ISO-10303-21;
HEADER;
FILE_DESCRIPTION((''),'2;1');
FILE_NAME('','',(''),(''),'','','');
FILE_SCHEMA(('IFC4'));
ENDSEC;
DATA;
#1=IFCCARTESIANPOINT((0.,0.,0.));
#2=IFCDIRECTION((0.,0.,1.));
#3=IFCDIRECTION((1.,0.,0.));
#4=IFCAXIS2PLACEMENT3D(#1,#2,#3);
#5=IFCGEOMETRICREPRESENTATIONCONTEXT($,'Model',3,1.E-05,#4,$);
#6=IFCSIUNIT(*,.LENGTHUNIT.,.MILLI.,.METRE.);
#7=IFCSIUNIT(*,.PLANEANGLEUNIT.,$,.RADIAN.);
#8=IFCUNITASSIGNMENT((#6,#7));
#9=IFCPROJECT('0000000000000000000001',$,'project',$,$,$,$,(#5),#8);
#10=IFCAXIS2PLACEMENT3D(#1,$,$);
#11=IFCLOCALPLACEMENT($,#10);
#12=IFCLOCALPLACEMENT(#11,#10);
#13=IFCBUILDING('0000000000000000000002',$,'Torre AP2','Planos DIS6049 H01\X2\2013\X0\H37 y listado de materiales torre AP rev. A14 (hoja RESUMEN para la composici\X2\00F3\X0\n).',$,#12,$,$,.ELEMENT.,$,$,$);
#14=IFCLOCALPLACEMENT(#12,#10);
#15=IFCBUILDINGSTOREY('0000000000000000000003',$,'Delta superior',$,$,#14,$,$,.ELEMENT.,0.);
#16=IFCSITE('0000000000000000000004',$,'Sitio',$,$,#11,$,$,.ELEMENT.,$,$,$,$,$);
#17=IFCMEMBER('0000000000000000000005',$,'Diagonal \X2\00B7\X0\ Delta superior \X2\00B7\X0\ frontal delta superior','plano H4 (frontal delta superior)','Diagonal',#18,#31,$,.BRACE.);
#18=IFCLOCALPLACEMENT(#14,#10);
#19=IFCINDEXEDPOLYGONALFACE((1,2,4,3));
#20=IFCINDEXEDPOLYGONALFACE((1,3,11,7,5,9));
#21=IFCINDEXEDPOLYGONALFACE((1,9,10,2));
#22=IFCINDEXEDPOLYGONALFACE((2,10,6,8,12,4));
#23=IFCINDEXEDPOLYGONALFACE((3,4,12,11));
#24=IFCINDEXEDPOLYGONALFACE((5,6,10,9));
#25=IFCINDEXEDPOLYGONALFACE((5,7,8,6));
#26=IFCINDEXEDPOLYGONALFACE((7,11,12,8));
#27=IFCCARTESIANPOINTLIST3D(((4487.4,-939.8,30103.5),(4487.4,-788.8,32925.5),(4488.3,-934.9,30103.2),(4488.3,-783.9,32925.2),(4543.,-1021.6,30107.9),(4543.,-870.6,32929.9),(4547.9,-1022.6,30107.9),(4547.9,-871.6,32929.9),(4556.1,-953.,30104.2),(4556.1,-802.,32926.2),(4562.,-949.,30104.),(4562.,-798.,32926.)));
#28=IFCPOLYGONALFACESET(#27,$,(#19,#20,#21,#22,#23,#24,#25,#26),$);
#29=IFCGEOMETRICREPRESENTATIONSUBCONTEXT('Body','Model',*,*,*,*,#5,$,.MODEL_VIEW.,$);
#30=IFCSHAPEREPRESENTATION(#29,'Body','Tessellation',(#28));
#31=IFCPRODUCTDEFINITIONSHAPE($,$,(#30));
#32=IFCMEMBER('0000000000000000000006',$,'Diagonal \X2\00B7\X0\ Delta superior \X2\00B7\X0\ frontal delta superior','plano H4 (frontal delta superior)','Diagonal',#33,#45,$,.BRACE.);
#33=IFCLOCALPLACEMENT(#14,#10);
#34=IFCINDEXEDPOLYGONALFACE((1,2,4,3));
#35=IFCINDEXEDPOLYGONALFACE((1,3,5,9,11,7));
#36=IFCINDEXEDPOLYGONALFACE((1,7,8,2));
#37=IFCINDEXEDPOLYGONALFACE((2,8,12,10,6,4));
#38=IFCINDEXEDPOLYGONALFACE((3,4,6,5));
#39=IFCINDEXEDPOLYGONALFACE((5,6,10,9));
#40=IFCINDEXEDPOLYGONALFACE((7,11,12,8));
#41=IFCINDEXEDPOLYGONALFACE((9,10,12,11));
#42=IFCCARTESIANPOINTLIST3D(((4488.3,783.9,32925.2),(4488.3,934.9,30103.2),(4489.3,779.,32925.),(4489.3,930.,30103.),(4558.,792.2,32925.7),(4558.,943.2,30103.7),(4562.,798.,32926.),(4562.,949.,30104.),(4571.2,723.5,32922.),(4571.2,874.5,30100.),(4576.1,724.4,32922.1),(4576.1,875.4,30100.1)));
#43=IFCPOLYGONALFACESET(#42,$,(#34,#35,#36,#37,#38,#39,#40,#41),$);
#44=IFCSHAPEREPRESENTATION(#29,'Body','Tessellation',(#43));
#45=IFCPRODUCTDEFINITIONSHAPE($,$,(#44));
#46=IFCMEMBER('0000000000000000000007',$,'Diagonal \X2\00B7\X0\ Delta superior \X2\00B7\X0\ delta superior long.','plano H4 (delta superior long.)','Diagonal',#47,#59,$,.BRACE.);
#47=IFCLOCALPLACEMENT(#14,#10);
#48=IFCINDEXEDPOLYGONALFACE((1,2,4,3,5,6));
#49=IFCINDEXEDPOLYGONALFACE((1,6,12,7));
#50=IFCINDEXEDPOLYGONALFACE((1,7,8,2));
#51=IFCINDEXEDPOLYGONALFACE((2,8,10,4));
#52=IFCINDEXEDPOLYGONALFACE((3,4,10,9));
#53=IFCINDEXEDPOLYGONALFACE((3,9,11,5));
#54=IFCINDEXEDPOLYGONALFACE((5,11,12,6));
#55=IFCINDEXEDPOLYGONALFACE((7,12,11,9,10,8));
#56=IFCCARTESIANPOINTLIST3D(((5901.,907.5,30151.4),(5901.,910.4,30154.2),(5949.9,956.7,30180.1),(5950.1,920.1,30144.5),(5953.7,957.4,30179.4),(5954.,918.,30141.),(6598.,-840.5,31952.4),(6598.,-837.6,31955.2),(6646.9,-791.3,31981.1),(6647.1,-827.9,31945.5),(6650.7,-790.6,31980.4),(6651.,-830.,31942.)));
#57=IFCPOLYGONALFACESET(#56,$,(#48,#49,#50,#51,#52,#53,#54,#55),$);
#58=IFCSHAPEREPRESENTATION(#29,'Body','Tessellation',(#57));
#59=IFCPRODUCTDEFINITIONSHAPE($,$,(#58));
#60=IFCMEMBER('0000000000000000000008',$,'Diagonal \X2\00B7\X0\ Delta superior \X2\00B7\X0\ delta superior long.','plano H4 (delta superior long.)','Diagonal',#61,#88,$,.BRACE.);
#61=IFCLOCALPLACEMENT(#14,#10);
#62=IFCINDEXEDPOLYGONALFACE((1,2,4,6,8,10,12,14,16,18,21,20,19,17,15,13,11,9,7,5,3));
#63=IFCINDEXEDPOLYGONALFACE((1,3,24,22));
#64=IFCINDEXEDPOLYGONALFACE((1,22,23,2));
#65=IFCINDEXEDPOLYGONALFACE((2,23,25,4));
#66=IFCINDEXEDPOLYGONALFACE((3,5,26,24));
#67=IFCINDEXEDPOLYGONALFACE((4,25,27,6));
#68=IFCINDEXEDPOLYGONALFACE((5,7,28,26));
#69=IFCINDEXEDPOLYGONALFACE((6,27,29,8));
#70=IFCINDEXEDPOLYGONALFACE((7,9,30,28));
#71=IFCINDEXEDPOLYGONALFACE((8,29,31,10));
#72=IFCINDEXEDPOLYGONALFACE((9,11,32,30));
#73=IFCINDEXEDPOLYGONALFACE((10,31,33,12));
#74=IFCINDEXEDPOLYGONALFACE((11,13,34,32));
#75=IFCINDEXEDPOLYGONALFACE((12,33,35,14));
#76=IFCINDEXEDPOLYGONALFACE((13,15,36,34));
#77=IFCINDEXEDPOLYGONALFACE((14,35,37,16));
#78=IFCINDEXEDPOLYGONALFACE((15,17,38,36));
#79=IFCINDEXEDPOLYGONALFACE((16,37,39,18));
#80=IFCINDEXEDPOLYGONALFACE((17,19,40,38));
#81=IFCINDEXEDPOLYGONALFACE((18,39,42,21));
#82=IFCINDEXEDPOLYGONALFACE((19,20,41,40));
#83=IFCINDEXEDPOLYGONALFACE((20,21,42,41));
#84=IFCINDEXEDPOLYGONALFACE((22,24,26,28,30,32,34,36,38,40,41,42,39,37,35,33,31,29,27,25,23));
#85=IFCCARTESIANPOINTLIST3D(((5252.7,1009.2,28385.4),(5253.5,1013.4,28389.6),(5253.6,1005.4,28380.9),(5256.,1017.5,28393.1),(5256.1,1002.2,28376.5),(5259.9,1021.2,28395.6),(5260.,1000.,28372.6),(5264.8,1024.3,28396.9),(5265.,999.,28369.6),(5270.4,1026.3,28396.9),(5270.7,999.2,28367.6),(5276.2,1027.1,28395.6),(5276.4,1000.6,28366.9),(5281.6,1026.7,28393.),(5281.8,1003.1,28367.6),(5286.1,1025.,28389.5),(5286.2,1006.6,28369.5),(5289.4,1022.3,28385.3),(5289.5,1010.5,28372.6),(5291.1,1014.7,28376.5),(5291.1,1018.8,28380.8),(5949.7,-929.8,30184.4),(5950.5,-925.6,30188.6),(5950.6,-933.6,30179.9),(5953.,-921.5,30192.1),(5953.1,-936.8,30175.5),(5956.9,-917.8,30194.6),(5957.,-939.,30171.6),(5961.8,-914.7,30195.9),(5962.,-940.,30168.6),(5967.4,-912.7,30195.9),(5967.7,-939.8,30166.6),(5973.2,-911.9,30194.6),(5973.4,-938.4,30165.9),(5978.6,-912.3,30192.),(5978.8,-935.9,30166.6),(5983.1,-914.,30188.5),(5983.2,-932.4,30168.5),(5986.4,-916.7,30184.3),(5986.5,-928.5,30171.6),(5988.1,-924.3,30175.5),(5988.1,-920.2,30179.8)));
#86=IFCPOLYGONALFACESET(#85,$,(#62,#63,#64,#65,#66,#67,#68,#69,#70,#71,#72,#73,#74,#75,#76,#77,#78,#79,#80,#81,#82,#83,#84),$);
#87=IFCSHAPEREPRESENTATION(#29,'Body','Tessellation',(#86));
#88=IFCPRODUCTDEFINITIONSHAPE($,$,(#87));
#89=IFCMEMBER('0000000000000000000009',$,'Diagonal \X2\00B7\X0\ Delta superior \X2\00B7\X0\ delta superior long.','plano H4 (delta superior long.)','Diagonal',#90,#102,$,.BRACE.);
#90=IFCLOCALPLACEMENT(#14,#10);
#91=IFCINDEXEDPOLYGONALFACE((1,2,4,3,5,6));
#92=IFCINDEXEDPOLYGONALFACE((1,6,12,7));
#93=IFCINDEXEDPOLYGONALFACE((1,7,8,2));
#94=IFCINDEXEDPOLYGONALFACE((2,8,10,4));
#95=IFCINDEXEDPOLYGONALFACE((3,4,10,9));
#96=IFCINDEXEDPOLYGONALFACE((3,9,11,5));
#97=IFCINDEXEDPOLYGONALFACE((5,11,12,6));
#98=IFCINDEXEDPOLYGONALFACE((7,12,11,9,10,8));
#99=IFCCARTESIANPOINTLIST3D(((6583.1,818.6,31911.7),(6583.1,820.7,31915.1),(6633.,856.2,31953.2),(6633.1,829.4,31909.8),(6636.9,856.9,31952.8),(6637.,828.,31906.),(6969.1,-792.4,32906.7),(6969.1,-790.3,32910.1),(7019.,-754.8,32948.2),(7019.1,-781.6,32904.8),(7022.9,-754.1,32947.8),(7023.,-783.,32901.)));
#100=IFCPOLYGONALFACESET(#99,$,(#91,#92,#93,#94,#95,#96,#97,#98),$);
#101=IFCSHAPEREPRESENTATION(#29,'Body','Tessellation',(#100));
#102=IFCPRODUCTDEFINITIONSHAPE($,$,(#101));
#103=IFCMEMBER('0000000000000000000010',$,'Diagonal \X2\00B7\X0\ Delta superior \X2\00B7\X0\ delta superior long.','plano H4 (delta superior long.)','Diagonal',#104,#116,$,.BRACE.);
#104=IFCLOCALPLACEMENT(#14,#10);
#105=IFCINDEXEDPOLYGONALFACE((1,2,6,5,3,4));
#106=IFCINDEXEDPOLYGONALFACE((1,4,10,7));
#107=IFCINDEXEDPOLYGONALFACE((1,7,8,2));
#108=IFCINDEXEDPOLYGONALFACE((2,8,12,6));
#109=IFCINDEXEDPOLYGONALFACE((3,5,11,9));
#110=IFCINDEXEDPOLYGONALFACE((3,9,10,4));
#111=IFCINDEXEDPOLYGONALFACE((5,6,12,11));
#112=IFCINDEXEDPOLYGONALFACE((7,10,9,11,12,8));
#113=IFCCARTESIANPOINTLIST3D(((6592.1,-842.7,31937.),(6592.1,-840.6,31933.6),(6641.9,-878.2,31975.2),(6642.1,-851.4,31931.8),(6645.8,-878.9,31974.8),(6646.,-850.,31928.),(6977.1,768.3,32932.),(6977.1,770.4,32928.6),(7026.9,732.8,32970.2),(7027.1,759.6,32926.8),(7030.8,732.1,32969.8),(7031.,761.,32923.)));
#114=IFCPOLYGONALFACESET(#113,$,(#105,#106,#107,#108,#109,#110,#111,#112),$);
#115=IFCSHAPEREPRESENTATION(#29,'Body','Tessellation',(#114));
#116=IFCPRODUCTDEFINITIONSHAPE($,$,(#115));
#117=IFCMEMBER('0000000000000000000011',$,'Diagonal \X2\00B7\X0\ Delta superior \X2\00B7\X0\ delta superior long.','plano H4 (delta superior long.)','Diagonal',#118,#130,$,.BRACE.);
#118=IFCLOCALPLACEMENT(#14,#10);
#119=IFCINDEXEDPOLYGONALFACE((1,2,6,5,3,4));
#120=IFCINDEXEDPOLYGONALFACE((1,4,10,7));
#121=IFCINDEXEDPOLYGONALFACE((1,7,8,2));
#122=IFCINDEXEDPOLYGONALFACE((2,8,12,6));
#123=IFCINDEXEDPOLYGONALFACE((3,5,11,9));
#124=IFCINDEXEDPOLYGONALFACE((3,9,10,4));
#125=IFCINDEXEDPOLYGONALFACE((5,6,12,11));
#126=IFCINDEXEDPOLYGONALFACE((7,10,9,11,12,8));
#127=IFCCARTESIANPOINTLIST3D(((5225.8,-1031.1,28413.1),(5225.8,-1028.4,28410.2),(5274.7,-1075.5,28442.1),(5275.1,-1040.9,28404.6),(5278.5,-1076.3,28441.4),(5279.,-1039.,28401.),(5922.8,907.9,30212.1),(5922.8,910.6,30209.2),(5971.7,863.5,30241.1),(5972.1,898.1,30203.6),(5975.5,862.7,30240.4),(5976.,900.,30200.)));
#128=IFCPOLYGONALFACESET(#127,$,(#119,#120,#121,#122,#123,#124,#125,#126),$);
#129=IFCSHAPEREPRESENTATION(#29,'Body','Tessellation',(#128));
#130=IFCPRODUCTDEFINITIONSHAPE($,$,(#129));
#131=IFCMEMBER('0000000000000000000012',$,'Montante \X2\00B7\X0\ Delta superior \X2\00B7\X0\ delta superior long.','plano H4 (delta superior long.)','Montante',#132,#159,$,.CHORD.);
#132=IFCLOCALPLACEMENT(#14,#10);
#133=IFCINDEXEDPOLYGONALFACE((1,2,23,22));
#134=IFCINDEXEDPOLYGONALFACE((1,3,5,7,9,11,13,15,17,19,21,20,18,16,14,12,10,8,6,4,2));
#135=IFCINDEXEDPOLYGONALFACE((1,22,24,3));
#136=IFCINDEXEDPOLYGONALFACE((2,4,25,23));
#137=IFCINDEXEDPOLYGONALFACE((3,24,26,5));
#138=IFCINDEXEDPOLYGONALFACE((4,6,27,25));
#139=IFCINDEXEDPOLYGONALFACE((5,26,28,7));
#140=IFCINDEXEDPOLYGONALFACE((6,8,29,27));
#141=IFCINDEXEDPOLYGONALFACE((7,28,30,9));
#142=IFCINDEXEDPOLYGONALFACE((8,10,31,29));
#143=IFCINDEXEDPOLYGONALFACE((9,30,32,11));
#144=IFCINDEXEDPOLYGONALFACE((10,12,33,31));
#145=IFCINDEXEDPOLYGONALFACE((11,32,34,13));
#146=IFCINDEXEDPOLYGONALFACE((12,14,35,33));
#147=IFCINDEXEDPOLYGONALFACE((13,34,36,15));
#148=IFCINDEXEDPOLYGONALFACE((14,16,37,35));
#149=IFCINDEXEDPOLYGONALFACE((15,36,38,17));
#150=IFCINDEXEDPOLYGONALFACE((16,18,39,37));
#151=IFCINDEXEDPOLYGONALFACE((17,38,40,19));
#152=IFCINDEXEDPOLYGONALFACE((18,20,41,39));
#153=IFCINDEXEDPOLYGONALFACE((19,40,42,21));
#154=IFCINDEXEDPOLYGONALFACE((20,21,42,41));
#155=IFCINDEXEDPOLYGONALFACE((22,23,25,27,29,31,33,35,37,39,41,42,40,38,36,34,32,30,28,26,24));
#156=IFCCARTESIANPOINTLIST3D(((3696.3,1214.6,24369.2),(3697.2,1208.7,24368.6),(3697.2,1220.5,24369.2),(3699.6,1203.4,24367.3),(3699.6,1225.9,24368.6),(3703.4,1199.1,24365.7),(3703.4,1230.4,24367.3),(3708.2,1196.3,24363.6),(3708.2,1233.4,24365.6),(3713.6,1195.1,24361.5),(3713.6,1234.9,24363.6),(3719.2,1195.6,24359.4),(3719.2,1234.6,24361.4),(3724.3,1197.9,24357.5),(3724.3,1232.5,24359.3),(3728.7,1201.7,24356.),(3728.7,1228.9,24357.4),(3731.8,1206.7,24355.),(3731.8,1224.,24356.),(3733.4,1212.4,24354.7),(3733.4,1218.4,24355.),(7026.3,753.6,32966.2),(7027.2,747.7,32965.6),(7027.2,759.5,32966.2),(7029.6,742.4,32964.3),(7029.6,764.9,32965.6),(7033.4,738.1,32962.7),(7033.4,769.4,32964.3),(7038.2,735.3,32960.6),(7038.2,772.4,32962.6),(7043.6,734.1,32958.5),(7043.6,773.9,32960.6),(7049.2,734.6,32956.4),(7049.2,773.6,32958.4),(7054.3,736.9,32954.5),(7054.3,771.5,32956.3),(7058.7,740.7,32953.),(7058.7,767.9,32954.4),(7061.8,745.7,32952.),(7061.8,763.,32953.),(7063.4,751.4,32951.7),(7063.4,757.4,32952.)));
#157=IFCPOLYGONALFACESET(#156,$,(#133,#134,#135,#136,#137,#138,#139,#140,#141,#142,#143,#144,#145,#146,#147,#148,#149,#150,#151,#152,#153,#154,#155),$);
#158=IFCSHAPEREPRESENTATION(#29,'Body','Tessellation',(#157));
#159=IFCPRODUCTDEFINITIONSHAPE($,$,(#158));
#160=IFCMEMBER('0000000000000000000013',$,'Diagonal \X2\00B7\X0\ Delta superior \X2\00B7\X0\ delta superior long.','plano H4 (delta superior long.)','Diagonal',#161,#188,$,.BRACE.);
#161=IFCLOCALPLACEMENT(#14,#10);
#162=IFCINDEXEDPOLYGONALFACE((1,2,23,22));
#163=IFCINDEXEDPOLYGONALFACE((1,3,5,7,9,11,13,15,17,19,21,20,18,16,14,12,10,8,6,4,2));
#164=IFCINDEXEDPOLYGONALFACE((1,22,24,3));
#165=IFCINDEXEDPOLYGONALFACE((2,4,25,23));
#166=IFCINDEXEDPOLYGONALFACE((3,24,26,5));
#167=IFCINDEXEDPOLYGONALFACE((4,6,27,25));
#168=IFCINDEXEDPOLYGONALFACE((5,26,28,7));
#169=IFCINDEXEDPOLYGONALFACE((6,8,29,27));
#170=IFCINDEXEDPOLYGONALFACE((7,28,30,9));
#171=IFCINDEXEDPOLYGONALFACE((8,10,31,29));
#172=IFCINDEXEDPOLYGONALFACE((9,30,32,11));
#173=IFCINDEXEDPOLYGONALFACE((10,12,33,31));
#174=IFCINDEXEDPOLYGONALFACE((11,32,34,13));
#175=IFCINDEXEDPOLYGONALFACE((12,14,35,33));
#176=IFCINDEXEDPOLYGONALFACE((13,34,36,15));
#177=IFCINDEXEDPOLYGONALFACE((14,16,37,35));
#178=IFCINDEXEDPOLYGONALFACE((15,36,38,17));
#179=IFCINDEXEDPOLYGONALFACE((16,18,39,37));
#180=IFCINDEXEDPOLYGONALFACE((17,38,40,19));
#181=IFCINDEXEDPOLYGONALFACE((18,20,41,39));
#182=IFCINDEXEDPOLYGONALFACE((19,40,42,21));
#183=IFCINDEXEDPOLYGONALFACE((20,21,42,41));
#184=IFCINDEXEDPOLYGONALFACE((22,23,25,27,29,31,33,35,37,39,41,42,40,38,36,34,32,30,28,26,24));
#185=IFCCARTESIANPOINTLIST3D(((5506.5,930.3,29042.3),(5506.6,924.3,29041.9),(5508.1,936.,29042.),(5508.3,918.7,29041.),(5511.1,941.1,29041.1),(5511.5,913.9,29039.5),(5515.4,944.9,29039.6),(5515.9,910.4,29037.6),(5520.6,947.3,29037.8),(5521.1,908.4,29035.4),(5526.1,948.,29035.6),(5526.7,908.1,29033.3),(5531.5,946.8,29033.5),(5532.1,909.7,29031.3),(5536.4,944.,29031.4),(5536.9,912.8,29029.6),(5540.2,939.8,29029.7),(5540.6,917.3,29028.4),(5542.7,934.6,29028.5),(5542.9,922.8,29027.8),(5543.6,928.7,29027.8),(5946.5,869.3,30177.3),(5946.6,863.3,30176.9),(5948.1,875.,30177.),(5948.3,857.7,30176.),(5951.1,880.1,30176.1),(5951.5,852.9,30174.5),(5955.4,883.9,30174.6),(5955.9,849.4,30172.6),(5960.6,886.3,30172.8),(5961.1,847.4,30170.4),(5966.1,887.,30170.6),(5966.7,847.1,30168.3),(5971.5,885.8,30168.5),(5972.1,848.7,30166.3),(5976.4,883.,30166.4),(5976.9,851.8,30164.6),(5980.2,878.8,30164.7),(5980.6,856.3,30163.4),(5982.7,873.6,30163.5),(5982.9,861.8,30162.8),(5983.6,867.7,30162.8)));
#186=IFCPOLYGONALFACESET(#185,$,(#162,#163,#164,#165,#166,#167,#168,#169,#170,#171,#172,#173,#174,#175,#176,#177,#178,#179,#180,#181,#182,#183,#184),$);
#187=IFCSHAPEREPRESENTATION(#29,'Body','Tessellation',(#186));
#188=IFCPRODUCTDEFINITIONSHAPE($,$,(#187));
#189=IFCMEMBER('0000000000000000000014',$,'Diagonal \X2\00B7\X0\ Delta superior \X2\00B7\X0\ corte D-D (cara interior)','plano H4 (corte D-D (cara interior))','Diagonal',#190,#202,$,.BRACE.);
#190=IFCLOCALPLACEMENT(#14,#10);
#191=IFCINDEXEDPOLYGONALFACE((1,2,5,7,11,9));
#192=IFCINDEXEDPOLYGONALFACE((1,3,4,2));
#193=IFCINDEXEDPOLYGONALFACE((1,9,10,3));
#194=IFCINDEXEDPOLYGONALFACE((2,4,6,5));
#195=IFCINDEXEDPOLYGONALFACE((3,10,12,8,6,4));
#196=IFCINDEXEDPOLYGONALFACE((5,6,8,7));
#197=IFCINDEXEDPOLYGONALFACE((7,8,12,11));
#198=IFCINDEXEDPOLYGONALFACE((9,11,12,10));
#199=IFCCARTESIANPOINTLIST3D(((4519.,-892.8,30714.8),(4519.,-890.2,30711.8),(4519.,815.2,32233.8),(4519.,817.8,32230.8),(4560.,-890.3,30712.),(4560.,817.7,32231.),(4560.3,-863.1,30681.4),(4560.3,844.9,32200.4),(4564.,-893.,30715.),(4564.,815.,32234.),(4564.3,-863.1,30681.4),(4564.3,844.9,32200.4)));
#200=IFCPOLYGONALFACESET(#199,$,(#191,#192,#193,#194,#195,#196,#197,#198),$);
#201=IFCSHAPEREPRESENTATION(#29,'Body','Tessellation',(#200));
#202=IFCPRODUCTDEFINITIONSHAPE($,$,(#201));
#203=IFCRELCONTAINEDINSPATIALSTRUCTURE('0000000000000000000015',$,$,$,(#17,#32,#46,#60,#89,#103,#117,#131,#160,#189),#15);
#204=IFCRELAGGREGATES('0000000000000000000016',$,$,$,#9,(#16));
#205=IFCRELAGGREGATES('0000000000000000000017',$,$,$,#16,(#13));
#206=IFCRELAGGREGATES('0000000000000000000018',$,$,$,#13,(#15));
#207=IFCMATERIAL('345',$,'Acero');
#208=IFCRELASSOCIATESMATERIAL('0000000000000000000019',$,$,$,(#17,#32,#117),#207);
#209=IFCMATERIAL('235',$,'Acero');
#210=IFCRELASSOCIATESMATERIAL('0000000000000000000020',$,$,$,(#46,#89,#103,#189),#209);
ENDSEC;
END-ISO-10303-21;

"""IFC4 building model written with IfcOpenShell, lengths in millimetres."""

from ifc_helpers import new_model, si_unit, frame, frame_2d, origin, origin_with_axes, place, context, subcontext, project, spatial, circle, l_section, extrude, material, element, save


model = new_model("IFC4")

# Units and contexts
model_context = context("Model", 3, precision=1e-05, world=origin_with_axes())
body_context = subcontext(model_context, "Body", "Model", "MODEL_VIEW")
ifc_project = project(units=[si_unit("LENGTHUNIT", "METRE", prefix="MILLI"), si_unit("PLANEANGLEUNIT", "RADIAN")], contexts=[model_context])

# Site, building, storey
site_placement = place(None, origin())
site = spatial("IfcSite", under=ifc_project, at=site_placement, Name="Sitio", CompositionType="ELEMENT")
building_placement = place(site_placement, origin())
building = spatial("IfcBuilding", under=site, at=building_placement, Name="Torre AP2", Description="Planos DIS6049 H01–H37 y listado de materiales torre AP rev. A14 (hoja RESUMEN para la composición).", CompositionType="ELEMENT")
storey_placement = place(building_placement, origin())
storey = spatial("IfcBuildingStorey", under=building, at=storey_placement, Name="Delta superior", CompositionType="ELEMENT", Elevation=0.0)

# Members
ifc_material_1 = material(Name="235", Category="Acero")
ifc_material_2 = material(Name="345", Category="Acero")
for number, where, z_axis, x_axis, name in (
    (1, (4562.0, -949.0, 30104.0), (0.0, 0.053432, 0.998572), (-0.982208, 0.187529, -0.010034), "Diagonal · Delta superior · frontal delta superior"),
    (2, (4562.0, 949.0, 30104.0), (0.0, -0.053432, 0.998572), (-0.982208, -0.187529, -0.010034), "Diagonal · Delta superior · frontal delta superior"),
):
    element("IfcMember", number, at=place(storey_placement, frame(where, z_axis=z_axis, x_axis=x_axis)), inside=storey, material=ifc_material_2, Name=name, Description="plano H4 (frontal delta superior)", ObjectType="Diagonal", PredefinedType="BRACE", context=body_context, shape_type="SweptSolid", body=[
        extrude(l_section(Depth=75.0, Width=75.0, Thickness=5.0, at=frame_2d((37.5, 37.5))), None, (0.0, 0.0, 1.0), 2826.0),
    ])
member_1_placement = place(storey_placement, frame((6651.0, -830.0, 31942.0), z_axis=(-0.267584, 0.671072, -0.691419), x_axis=(-0.963521, -0.190088, 0.188396)))
element("IfcMember", 3, at=member_1_placement, inside=storey, material=ifc_material_1, Name="Diagonal · Delta superior · delta superior long.", Description="plano H4 (delta superior long.)", ObjectType="Diagonal", PredefinedType="BRACE", context=body_context, shape_type="SweptSolid", body=[
    extrude(l_section(Depth=55.0, Width=55.0, Thickness=4.0, at=frame_2d((27.5, 27.5))), None, (0.0, 0.0, 1.0), 2604.8),
])
member_2_placement = place(storey_placement, frame((5969.0, -926.0, 30181.0), z_axis=(-0.254816, 0.708877, -0.657695), x_axis=(-0.966975, -0.190493, 0.169325)))
element("IfcMember", 4, at=member_2_placement, inside=storey, Name="Diagonal · Delta superior · delta superior long.", Description="plano H4 (delta superior long.)", ObjectType="Diagonal", PredefinedType="BRACE", context=body_context, shape_type="SweptSolid", body=[
    extrude(circle(Radius=20.0), None, (0.0, 0.0, 1.0), 2735.3),
])
member_3_placement = place(storey_placement, frame((7023.0, -783.0, 32901.0), z_axis=(-0.199747, 0.833659, -0.514892), x_axis=(-0.979846, -0.170873, 0.103461)))
element("IfcMember", 5, at=member_3_placement, inside=storey, material=ifc_material_1, Name="Diagonal · Delta superior · delta superior long.", Description="plano H4 (delta superior long.)", ObjectType="Diagonal", PredefinedType="BRACE", context=body_context, shape_type="SweptSolid", body=[
    extrude(l_section(Depth=55.0, Width=55.0, Thickness=4.0, at=frame_2d((27.5, 27.5))), None, (0.0, 0.0, 1.0), 1932.4),
])
member_4_placement = place(storey_placement, frame((6646.0, -850.0, 31928.0), z_axis=(0.19925, 0.833745, 0.514945), x_axis=(-0.979943, 0.171353, 0.101736)))
element("IfcMember", 6, at=member_4_placement, inside=storey, material=ifc_material_1, Name="Diagonal · Delta superior · delta superior long.", Description="plano H4 (delta superior long.)", ObjectType="Diagonal", PredefinedType="BRACE", context=body_context, shape_type="SweptSolid", body=[
    extrude(l_section(Depth=55.0, Width=55.0, Thickness=4.0, at=frame_2d((27.5, 27.5))), None, (0.0, 0.0, 1.0), 1932.2),
])
member_5_placement = place(storey_placement, frame((5279.0, -1039.0, 28401.0), z_axis=(0.254816, 0.708877, 0.657695), x_axis=(-0.966953, 0.192686, 0.166953)))
element("IfcMember", 7, at=member_5_placement, inside=storey, material=ifc_material_2, Name="Diagonal · Delta superior · delta superior long.", Description="plano H4 (delta superior long.)", ObjectType="Diagonal", PredefinedType="BRACE", context=body_context, shape_type="SweptSolid", body=[
    extrude(l_section(Depth=55.0, Width=55.0, Thickness=4.0, at=frame_2d((27.5, 27.5))), None, (0.0, 0.0, 1.0), 2735.3),
])
for number, where, z_axis, x_axis, name in (
    (8, (3715.0, 1215.0, 24362.0), (0.360744, -0.049941, 0.931327), (-0.932665, -0.019317, 0.360227), "Montante · Delta superior · delta superior long."),
):
    element("IfcMember", number, at=place(storey_placement, frame(where, z_axis=z_axis, x_axis=x_axis)), inside=storey, Name=name, Description="plano H4 (delta superior long.)", ObjectType="Montante", PredefinedType="CHORD", context=body_context, shape_type="SweptSolid", body=[
        extrude(circle(Radius=20.0), None, (0.0, 0.0, 1.0), 9230.9),
    ])
member_6_placement = place(storey_placement, frame((5525.0, 928.0, 29035.0), z_axis=(0.361002, -0.050048, 0.931221), x_axis=(-0.919866, -0.183339, 0.346747)))
element("IfcMember", 9, at=member_6_placement, inside=storey, Name="Diagonal · Delta superior · delta superior long.", Description="plano H4 (delta superior long.)", ObjectType="Diagonal", PredefinedType="BRACE", context=body_context, shape_type="SweptSolid", body=[
    extrude(circle(Radius=20.0), None, (0.0, 0.0, 1.0), 1218.8),
])
member_7_placement = place(storey_placement, frame((4564.0, 815.0, 32234.0), z_axis=(0.0, -0.74724, -0.664554), x_axis=(-0.999984, 0.003774, -0.004243)))
element("IfcMember", 10, at=member_7_placement, inside=storey, material=ifc_material_1, Name="Diagonal · Delta superior · corte D-D (cara interior)", Description="plano H4 (corte D-D (cara interior))", ObjectType="Diagonal", PredefinedType="BRACE", context=body_context, shape_type="SweptSolid", body=[
    extrude(l_section(Depth=45.0, Width=45.0, Thickness=4.0, at=frame_2d((22.5, 22.5))), None, (0.0, 0.0, 1.0), 2285.7),
])

save(model, "model.ifc")
